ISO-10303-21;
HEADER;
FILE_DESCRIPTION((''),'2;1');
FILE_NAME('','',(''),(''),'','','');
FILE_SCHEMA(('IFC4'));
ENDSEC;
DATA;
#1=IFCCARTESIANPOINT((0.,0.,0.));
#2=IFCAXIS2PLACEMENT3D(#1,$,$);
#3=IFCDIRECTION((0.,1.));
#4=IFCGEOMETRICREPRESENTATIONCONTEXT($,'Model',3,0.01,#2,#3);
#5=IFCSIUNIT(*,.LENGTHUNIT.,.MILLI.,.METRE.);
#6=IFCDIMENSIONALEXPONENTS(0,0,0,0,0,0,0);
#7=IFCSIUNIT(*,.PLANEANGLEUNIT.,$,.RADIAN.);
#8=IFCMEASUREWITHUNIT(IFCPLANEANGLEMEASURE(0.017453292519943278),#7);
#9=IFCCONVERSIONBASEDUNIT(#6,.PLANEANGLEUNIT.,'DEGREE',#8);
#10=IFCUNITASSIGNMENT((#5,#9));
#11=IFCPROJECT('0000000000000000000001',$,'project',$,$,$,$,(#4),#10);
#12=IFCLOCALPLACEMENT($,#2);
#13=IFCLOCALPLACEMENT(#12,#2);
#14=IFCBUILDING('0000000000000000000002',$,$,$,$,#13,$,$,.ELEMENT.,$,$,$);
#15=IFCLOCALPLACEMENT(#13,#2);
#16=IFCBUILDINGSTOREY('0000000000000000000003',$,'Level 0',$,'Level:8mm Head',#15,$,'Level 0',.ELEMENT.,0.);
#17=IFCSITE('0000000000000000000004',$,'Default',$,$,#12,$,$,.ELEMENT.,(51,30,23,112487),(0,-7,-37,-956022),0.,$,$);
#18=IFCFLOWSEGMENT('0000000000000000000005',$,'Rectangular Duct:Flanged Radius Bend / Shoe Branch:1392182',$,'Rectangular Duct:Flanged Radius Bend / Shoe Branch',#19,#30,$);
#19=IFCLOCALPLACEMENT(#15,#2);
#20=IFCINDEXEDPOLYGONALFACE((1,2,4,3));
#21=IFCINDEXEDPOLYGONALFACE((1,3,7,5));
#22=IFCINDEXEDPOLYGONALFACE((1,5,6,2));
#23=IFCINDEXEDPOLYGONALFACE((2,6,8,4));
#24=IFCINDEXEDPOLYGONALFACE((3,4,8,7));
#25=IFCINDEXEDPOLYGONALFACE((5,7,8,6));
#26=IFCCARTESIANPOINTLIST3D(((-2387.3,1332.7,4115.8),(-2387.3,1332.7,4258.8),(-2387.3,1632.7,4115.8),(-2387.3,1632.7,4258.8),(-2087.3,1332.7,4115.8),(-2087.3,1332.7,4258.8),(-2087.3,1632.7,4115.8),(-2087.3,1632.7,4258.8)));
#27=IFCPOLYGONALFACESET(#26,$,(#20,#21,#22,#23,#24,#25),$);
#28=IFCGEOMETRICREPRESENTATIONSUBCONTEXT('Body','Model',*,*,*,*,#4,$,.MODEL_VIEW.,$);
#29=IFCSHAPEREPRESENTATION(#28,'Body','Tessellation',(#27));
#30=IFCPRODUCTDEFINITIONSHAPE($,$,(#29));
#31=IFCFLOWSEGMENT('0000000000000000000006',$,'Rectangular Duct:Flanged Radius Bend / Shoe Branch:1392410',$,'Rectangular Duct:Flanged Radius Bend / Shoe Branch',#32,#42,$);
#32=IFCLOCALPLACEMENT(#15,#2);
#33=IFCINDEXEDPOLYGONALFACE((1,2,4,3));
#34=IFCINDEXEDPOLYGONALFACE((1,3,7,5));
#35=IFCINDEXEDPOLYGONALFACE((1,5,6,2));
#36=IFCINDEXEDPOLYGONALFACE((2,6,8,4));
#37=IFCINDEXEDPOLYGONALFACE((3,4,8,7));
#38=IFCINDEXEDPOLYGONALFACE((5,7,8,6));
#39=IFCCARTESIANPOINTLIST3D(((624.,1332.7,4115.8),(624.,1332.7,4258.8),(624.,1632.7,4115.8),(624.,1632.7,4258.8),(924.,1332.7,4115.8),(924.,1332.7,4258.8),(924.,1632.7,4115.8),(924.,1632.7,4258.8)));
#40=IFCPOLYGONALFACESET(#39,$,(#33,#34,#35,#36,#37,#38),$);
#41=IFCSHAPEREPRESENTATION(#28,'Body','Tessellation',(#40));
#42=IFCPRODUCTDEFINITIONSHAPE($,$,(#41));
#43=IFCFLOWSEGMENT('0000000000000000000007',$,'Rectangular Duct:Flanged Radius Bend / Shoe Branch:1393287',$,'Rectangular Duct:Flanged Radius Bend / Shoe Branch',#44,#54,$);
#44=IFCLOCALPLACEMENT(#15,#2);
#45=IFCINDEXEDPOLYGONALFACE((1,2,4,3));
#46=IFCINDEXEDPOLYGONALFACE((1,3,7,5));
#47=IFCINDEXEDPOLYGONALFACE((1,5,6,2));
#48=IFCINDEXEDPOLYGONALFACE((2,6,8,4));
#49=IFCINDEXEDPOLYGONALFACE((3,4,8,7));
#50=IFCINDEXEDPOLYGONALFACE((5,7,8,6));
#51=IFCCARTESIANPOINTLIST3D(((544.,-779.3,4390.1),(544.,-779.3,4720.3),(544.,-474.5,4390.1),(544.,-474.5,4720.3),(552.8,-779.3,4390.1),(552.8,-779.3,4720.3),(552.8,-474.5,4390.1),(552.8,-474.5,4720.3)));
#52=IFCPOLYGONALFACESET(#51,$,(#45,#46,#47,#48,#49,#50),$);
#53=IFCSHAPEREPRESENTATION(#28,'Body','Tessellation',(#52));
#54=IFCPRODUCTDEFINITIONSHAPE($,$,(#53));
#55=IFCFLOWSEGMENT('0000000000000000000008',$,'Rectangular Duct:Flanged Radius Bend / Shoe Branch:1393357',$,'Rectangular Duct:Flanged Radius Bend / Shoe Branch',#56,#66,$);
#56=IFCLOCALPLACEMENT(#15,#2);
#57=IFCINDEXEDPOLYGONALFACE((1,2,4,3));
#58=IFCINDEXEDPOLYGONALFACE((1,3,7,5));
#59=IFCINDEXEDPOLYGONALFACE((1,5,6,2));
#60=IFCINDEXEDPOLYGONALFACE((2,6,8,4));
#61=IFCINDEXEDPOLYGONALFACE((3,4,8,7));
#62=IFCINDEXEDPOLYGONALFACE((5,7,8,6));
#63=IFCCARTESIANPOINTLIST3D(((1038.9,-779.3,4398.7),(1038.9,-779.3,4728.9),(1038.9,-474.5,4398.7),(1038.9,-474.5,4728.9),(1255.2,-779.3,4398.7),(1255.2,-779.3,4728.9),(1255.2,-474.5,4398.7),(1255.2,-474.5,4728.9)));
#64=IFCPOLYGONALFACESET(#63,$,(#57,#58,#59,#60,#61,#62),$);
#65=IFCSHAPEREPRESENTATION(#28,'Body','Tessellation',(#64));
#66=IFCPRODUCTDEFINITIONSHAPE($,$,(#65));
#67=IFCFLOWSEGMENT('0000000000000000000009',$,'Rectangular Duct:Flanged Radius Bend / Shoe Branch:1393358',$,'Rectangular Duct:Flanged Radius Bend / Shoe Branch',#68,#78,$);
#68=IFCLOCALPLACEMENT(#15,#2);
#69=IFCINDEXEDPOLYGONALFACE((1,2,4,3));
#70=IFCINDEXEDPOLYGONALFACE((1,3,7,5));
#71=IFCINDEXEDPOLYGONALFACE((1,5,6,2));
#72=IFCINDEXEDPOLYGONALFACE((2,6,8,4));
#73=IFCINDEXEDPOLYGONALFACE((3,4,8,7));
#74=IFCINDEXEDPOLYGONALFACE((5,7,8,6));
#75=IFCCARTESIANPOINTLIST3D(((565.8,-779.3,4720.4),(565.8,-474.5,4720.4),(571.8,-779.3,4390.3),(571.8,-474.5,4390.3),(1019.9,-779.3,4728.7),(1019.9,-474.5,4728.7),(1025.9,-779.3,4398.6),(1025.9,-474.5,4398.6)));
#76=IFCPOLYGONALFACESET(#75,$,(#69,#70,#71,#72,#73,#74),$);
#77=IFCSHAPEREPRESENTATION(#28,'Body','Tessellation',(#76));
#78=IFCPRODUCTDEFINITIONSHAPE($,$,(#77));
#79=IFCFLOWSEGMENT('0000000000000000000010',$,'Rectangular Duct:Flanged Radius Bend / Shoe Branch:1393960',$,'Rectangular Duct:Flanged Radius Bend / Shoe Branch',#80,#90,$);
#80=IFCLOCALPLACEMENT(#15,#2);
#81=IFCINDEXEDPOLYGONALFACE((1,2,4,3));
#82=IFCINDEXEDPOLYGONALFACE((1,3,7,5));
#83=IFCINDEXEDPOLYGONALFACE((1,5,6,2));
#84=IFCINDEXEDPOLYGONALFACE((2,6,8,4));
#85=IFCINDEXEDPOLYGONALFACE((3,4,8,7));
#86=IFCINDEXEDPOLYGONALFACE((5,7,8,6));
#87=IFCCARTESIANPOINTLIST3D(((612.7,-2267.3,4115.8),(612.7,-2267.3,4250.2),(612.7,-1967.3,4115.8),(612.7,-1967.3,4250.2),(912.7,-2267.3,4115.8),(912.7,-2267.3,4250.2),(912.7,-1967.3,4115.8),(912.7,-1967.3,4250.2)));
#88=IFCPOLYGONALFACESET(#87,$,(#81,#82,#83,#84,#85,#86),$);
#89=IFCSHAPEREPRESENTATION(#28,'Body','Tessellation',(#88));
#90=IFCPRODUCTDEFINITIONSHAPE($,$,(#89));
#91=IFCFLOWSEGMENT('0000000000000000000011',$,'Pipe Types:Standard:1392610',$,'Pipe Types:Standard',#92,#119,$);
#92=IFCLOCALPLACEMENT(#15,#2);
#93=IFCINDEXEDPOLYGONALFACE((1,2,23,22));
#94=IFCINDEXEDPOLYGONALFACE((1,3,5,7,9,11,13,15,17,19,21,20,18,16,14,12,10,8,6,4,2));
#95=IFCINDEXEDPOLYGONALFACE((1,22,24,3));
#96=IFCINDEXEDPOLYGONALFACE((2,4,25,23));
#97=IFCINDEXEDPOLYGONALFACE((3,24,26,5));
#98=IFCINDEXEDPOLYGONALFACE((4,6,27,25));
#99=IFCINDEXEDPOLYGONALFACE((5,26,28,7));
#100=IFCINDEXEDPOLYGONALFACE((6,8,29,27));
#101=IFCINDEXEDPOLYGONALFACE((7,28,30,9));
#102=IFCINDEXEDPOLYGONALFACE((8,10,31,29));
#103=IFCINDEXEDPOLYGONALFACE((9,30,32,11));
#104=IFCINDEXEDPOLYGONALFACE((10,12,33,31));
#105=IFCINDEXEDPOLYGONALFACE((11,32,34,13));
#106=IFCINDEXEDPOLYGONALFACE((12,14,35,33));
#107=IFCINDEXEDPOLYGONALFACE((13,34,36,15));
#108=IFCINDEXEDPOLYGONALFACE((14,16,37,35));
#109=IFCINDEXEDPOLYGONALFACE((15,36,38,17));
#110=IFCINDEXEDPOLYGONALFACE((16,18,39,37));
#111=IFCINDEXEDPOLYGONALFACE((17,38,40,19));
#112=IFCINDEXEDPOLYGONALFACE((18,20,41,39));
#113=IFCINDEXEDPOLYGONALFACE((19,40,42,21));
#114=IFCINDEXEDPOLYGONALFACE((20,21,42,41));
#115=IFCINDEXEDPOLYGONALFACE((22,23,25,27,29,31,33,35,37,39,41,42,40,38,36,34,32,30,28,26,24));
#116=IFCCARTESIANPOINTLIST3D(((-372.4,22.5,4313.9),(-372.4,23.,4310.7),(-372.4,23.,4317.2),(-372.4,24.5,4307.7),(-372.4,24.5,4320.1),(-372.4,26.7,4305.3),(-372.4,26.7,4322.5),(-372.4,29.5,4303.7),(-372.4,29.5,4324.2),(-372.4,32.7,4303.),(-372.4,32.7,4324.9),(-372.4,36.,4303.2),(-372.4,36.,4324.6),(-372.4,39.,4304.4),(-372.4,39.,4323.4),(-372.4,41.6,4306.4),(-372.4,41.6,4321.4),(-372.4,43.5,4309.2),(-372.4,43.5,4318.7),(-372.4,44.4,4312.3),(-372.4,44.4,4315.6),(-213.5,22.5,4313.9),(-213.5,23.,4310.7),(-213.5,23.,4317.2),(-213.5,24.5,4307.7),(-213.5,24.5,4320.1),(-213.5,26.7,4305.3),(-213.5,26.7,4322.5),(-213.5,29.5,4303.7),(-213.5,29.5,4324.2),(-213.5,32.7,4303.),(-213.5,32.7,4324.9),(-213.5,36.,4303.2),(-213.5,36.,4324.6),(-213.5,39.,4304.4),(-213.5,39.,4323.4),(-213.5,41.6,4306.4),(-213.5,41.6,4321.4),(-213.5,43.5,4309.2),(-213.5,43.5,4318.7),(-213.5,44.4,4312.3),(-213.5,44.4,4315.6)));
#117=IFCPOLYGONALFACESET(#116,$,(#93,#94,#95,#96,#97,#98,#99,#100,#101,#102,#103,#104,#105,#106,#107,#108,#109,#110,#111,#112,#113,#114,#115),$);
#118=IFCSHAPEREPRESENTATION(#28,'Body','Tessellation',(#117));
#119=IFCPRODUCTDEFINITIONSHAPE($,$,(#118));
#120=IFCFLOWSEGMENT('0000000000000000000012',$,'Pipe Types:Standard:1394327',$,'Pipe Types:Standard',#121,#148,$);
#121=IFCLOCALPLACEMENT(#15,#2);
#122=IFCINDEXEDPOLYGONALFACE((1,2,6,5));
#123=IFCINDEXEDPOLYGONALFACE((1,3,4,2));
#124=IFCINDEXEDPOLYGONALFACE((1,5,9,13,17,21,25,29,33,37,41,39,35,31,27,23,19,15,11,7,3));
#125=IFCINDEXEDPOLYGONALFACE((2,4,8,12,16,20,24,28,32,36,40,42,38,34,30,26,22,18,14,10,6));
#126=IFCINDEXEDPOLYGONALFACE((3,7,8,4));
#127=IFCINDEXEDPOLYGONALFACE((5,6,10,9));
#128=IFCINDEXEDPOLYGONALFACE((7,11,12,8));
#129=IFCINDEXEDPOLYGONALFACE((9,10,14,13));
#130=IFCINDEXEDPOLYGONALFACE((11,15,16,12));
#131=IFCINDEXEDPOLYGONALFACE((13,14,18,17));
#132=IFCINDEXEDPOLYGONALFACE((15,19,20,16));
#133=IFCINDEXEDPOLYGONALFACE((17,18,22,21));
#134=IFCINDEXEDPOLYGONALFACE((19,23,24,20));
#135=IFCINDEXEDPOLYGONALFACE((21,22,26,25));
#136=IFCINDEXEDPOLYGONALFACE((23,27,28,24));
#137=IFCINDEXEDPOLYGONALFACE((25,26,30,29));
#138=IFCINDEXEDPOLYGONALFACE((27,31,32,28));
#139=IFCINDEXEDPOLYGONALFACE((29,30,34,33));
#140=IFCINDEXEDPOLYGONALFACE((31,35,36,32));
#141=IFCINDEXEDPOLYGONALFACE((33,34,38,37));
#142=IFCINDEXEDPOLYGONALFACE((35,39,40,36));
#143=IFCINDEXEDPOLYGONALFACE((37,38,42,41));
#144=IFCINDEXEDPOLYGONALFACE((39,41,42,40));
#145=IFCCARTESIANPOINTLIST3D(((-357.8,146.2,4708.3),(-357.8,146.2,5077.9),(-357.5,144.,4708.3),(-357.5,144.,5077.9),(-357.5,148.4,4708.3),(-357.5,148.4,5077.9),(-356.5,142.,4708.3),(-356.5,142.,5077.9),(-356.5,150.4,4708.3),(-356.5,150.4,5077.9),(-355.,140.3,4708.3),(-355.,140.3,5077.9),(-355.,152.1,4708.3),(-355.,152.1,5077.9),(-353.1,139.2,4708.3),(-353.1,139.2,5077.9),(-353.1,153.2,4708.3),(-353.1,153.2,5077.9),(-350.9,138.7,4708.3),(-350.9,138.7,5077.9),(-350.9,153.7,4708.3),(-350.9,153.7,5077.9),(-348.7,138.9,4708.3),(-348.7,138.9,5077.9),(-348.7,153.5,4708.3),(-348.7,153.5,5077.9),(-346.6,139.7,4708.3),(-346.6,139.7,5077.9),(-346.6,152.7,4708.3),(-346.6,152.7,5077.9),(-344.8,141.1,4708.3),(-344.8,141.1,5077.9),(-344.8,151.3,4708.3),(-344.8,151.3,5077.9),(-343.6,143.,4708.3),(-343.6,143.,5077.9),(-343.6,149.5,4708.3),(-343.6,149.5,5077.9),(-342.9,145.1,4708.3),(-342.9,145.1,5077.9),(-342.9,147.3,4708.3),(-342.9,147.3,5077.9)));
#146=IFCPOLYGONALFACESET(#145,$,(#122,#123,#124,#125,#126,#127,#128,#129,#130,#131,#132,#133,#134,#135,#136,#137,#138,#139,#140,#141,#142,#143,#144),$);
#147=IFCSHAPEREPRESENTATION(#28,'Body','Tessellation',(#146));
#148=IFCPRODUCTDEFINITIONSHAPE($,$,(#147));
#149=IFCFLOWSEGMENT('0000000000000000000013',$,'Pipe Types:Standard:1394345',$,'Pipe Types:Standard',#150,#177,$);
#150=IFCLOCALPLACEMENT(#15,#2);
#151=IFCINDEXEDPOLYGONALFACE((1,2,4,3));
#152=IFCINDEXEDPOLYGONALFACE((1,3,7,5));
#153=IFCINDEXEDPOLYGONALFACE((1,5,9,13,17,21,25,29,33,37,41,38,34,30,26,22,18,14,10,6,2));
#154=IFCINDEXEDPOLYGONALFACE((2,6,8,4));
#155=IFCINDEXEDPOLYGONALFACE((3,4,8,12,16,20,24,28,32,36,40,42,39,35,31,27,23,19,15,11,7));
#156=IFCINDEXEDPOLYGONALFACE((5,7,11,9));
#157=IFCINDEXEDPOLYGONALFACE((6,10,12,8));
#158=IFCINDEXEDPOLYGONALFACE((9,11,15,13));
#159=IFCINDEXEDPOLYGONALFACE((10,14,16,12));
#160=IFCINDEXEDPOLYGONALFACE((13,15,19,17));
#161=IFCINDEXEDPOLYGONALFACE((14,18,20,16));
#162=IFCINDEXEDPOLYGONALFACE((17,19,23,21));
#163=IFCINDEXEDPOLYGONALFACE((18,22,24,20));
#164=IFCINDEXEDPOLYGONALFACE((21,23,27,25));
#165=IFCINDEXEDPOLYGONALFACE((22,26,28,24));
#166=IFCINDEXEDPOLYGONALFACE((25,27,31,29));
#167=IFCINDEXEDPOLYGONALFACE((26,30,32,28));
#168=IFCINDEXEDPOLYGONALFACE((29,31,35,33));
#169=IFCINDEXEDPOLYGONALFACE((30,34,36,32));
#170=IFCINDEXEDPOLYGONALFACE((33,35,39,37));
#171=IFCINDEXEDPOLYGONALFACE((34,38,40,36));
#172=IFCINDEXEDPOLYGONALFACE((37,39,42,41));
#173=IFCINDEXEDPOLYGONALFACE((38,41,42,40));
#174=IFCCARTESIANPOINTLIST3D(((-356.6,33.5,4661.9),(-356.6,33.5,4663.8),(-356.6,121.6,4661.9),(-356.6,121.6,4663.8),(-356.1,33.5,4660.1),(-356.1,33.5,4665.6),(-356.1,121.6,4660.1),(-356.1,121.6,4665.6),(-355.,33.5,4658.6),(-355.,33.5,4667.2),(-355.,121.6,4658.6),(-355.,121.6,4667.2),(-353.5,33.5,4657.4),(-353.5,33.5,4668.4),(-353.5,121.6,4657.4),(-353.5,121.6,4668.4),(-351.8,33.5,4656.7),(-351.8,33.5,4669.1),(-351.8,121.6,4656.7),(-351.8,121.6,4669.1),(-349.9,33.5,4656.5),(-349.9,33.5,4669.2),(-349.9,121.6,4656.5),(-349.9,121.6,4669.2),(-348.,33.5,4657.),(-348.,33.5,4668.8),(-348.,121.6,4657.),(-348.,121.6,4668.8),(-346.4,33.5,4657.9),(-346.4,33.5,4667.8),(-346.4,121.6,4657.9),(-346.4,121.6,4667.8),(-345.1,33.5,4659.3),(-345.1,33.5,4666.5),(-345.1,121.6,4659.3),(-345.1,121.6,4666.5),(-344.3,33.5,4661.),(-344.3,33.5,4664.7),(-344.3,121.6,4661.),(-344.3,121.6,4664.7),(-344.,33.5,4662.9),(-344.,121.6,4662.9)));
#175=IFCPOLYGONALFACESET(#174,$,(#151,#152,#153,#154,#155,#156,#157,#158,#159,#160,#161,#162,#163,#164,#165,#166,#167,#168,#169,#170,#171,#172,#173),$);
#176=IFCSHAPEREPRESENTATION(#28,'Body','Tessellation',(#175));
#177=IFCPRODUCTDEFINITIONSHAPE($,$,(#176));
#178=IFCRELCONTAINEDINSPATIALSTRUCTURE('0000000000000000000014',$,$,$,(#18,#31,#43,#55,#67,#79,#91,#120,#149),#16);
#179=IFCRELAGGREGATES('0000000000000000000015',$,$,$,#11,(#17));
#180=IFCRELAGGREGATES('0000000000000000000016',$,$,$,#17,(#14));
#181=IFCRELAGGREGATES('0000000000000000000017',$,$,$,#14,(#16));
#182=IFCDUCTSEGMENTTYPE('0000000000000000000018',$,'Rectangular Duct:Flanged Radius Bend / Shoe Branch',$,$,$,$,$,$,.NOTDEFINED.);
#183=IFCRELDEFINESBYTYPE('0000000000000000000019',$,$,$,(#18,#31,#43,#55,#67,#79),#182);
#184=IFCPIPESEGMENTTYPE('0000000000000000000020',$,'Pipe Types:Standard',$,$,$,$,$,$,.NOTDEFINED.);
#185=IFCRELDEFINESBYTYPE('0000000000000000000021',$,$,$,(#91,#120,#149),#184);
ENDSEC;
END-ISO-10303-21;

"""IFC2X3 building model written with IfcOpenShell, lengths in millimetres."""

from ifc_helpers import new_model, entity, si_unit, converted_unit, direction, frame, frame_2d, origin, origin_2d_with_axis, place, context, subcontext, project, spatial, rectangle, circle, extrude, type_object, element, save


model = new_model("IFC2X3")

# Units and contexts
model_context = context("Model", 3, precision=0.01, world=origin(), true_north=direction((0.0, 1.0)))
body_context = subcontext(model_context, "Body", "Model", "MODEL_VIEW")
ifc_project = project(units=[si_unit("LENGTHUNIT", "METRE", prefix="MILLI"), converted_unit("PLANEANGLEUNIT", "DEGREE", entity("IfcPlaneAngleMeasure", 0.017453292519943278), si_unit("PLANEANGLEUNIT", "RADIAN"), dimensions=[0, 0, 0, 0, 0, 0, 0])], contexts=[model_context])

# Site, building, storey
site_placement = place(None, origin())
site = spatial("IfcSite", under=ifc_project, at=site_placement, Name="Default", CompositionType="ELEMENT", RefLatitude=(51, 30, 23, 112487), RefLongitude=(0, -7, -37, -956022), RefElevation=0.0)
building_placement = place(site_placement, origin())
building = spatial("IfcBuilding", under=site, at=building_placement, CompositionType="ELEMENT")
storey_placement = place(building_placement, origin())
storey = spatial("IfcBuildingStorey", under=building, at=storey_placement, Name="Level 0", ObjectType="Level:8mm Head", LongName="Level 0", CompositionType="ELEMENT", Elevation=0.0)

# Flow segments
duct_segment_type = type_object("IfcDuctSegmentType", Name="Rectangular Duct:Flanged Radius Bend / Shoe Branch", PredefinedType="NOTDEFINED")
flow_segment_1_placement = place(storey_placement, origin())
element("IfcFlowSegment", 1, at=flow_segment_1_placement, inside=storey, type_object=duct_segment_type, Name="Rectangular Duct:Flanged Radius Bend / Shoe Branch:1392182", ObjectType="Rectangular Duct:Flanged Radius Bend / Shoe Branch", context=body_context, shape_type="SweptSolid", body=[
    extrude(rectangle(XDim=300.0, YDim=300.0, at=origin_2d_with_axis()), frame((-2237.3, 1482.7, 4115.8), z_axis=(0.0, 0.0, 1.0), x_axis=(-1.0, 0.0, 0.0)), (0.0, 0.0, 1.0), 143.0),
])
flow_segment_2_placement = place(storey_placement, origin())
element("IfcFlowSegment", 2, at=flow_segment_2_placement, inside=storey, type_object=duct_segment_type, Name="Rectangular Duct:Flanged Radius Bend / Shoe Branch:1392410", ObjectType="Rectangular Duct:Flanged Radius Bend / Shoe Branch", context=body_context, shape_type="SweptSolid", body=[
    extrude(rectangle(XDim=300.0, YDim=300.0, at=origin_2d_with_axis()), frame((774.0, 1482.7, 4115.8)), (0.0, 0.0, 1.0), 143.0),
])
flow_segment_3_placement = place(storey_placement, origin())
element("IfcFlowSegment", 3, at=flow_segment_3_placement, inside=storey, type_object=duct_segment_type, Name="Rectangular Duct:Flanged Radius Bend / Shoe Branch:1393287", ObjectType="Rectangular Duct:Flanged Radius Bend / Shoe Branch", context=body_context, shape_type="SweptSolid", body=[
    extrude(rectangle(XDim=8.8, YDim=304.8, at=origin_2d_with_axis()), frame((548.4, -626.9, 4390.1), z_axis=(0.0, 0.0, 1.0), x_axis=(-1.0, 0.0, 0.0)), (0.0, 0.0, 1.0), 330.2),
])
flow_segment_4_placement = place(storey_placement, origin())
element("IfcFlowSegment", 4, at=flow_segment_4_placement, inside=storey, type_object=duct_segment_type, Name="Rectangular Duct:Flanged Radius Bend / Shoe Branch:1393357", ObjectType="Rectangular Duct:Flanged Radius Bend / Shoe Branch", context=body_context, shape_type="SweptSolid", body=[
    extrude(rectangle(XDim=216.3, YDim=304.8, at=frame_2d((0.0, 0.0), x_axis=(1.0, 0.0))), frame((1147.1, -626.9, 4398.7), z_axis=(0.0, 0.0, 1.0), x_axis=(-1.0, 0.0, 0.0)), (0.0, 0.0, 1.0), 330.2),
])
flow_segment_5_placement = place(storey_placement, origin())
element("IfcFlowSegment", 5, at=flow_segment_5_placement, inside=storey, type_object=duct_segment_type, Name="Rectangular Duct:Flanged Radius Bend / Shoe Branch:1393358", ObjectType="Rectangular Duct:Flanged Radius Bend / Shoe Branch", context=body_context, shape_type="SweptSolid", body=[
    extrude(rectangle(XDim=330.2, YDim=304.8, at=frame_2d((0.0, 0.0), x_axis=(0.0, 1.0))), frame((568.8, -626.9, 4555.4), z_axis=(0.999833, 0.0, 0.018291), x_axis=(0.0, 1.0, 0.0)), (0.0, 0.0, 1.0), 454.1),
])
flow_segment_6_placement = place(storey_placement, origin())
element("IfcFlowSegment", 6, at=flow_segment_6_placement, inside=storey, type_object=duct_segment_type, Name="Rectangular Duct:Flanged Radius Bend / Shoe Branch:1393960", ObjectType="Rectangular Duct:Flanged Radius Bend / Shoe Branch", context=body_context, shape_type="SweptSolid", body=[
    extrude(rectangle(XDim=300.0, YDim=300.0, at=origin_2d_with_axis()), frame((762.7, -2117.3, 4115.8), z_axis=(0.0, 0.0, 1.0), x_axis=(0.0, 1.0, 0.0)), (0.0, 0.0, 1.0), 134.4),
])

# Flow segments
pipe_segment_type = type_object("IfcPipeSegmentType", Name="Pipe Types:Standard", PredefinedType="NOTDEFINED")
flow_segment_7_placement = place(storey_placement, origin())
element("IfcFlowSegment", 7, at=flow_segment_7_placement, inside=storey, type_object=pipe_segment_type, Name="Pipe Types:Standard:1392610", ObjectType="Pipe Types:Standard", context=body_context, shape_type="SweptSolid", body=[
    extrude(circle(Radius=11.0, at=frame_2d((0.0, 0.0), x_axis=(1.0, 0.0))), frame((-372.4, 33.5, 4313.9), z_axis=(1.0, 0.0, 0.0), x_axis=(0.0, -1.0, 0.0)), (0.0, 0.0, 1.0), 158.9),
])
flow_segment_8_placement = place(storey_placement, origin())
element("IfcFlowSegment", 8, at=flow_segment_8_placement, inside=storey, type_object=pipe_segment_type, Name="Pipe Types:Standard:1394327", ObjectType="Pipe Types:Standard", context=body_context, shape_type="SweptSolid", body=[
    extrude(circle(Radius=7.5, at=frame_2d((0.0, 0.0), x_axis=(1.0, 0.0))), frame((-350.3, 146.2, 4708.3), z_axis=(0.0, 0.0, 1.0), x_axis=(-1.0, 0.0, 0.0)), (0.0, 0.0, 1.0), 369.6),
])
flow_segment_9_placement = place(storey_placement, origin())
element("IfcFlowSegment", 9, at=flow_segment_9_placement, inside=storey, type_object=pipe_segment_type, Name="Pipe Types:Standard:1394345", ObjectType="Pipe Types:Standard", context=body_context, shape_type="SweptSolid", body=[
    extrude(circle(Radius=6.4, at=frame_2d((0.0, 0.0), x_axis=(1.0, 0.0))), frame((-350.3, 33.5, 4662.9), z_axis=(0.0, 1.0, 0.0), x_axis=(1.0, 0.0, 0.0)), (0.0, 0.0, 1.0), 88.1),
])

save(model, "model.ifc")
